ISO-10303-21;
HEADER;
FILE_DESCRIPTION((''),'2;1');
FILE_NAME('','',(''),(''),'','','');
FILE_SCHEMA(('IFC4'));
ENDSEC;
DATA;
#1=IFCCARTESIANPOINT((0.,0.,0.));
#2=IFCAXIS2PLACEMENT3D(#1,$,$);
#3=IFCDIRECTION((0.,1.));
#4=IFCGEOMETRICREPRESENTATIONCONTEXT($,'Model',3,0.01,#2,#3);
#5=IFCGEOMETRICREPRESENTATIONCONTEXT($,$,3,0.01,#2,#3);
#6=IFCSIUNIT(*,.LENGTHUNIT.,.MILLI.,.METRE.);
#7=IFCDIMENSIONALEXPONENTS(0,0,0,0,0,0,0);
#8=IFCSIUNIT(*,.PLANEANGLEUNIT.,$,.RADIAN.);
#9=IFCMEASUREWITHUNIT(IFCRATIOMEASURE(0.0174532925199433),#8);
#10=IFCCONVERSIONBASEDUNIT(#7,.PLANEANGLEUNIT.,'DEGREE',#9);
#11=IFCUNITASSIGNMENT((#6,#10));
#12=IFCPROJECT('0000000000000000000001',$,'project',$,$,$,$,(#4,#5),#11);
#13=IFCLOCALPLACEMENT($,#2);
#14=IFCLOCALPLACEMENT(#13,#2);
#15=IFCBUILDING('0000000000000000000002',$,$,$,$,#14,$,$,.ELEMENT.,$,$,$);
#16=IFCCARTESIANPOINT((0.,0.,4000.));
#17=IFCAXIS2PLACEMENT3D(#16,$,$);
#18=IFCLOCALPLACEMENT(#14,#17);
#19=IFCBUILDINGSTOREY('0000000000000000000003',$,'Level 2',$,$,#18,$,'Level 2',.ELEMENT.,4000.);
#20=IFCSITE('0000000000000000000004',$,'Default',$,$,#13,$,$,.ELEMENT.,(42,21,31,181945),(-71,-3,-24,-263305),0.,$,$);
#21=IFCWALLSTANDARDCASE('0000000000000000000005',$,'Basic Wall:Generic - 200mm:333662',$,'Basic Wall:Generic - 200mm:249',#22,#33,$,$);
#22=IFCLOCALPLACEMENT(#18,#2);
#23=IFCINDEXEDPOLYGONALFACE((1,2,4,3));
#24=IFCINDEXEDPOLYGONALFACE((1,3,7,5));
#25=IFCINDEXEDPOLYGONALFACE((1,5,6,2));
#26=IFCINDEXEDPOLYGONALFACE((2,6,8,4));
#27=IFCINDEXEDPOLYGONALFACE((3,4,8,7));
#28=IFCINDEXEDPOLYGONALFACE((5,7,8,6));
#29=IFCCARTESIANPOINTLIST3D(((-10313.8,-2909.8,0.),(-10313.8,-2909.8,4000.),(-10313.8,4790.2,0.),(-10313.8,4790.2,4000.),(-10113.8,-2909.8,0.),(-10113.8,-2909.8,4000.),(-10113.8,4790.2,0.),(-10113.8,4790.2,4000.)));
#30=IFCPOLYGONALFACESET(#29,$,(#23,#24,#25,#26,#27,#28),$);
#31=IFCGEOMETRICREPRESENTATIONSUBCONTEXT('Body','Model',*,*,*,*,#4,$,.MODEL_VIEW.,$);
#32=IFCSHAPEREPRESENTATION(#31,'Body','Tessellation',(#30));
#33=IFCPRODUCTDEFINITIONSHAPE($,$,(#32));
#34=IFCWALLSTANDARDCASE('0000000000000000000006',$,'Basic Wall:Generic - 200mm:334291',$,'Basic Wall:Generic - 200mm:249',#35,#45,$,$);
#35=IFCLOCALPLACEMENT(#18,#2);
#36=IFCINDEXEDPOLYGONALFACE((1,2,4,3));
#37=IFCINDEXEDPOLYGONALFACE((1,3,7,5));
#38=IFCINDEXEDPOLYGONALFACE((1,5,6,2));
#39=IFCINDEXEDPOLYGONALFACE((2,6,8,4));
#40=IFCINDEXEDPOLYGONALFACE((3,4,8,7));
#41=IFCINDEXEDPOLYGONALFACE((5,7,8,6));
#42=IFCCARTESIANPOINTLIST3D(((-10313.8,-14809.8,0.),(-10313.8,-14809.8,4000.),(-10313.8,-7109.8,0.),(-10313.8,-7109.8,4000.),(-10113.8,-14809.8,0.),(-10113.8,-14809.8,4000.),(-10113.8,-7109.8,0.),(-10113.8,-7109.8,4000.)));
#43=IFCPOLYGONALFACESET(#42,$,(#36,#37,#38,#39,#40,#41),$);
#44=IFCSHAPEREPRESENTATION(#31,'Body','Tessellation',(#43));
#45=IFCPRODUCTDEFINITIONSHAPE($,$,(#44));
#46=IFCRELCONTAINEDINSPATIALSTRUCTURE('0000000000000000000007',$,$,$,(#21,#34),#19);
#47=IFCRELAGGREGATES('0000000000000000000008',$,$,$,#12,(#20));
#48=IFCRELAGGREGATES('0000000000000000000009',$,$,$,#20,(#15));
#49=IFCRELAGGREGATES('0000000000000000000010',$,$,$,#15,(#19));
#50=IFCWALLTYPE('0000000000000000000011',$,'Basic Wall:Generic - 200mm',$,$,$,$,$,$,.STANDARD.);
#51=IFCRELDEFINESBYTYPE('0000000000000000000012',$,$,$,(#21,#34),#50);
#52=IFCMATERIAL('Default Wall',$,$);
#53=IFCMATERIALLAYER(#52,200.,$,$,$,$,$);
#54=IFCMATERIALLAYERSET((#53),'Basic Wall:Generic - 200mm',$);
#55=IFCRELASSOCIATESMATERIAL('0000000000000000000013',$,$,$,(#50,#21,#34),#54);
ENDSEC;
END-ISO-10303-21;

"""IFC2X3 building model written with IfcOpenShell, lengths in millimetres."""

from ifc_helpers import new_model, entity, si_unit, converted_unit, direction, frame, frame_2d, origin, place, context, subcontext, project, spatial, rectangle, extrude, clip, halfspace, material, layer, layer_set, layer_usage, type_object, element, save


model = new_model("IFC2X3")

# Units and contexts
model_context = context("Model", 3, precision=0.01, world=origin(), true_north=direction((0.0, 1.0)))
context_of_model = context(None, 3, precision=0.01, world=origin(), true_north=direction((0.0, 1.0)))
body_context = subcontext(model_context, "Body", "Model", "MODEL_VIEW")
ifc_project = project(units=[si_unit("LENGTHUNIT", "METRE", prefix="MILLI"), converted_unit("PLANEANGLEUNIT", "DEGREE", entity("IfcRatioMeasure", 0.0174532925199433), si_unit("PLANEANGLEUNIT", "RADIAN"), dimensions=[0, 0, 0, 0, 0, 0, 0])], contexts=[model_context, context_of_model])

# Site, building, storey
site_placement = place(None, origin())
site = spatial("IfcSite", under=ifc_project, at=site_placement, Name="Default", CompositionType="ELEMENT", RefLatitude=(42, 21, 31, 181945), RefLongitude=(-71, -3, -24, -263305), RefElevation=0.0)
building_placement = place(site_placement, origin())
building = spatial("IfcBuilding", under=site, at=building_placement, CompositionType="ELEMENT")
storey_placement = place(building_placement, frame((0.0, 0.0, 4000.0)))
storey = spatial("IfcBuildingStorey", under=building, at=storey_placement, Name="Level 2", LongName="Level 2", CompositionType="ELEMENT", Elevation=4000.0)

# Walls
ifc_material = material(Name="Default Wall")
ifc_layer = layer(ifc_material, 200.0)
ifc_layer_set = layer_set([ifc_layer], Name="Basic Wall:Generic - 200mm")
ifc_layer_usage_1 = layer_usage(ifc_layer_set, "AXIS2", "NEGATIVE", 100.0)
wall_type = type_object("IfcWallType", Name="Basic Wall:Generic - 200mm", PredefinedType="STANDARD", material=ifc_layer_set)
wall_1_placement = place(storey_placement, frame((-10213.8, 4790.2, 0.0), z_axis=(0.0, 0.0, 1.0), x_axis=(0.0, -1.0, 0.0)))
element("IfcWallStandardCase", 1, at=wall_1_placement, inside=storey, type_object=wall_type, material=ifc_layer_usage_1, Name="Basic Wall:Generic - 200mm:333662", ObjectType="Basic Wall:Generic - 200mm:249", context=body_context, shape_type="Clipping", body=[
    clip(extrude(rectangle(XDim=7700.0, YDim=200.0, at=frame_2d((3850.0, 0.0), x_axis=(-1.0, 0.0))), origin(), (0.0, 0.0, 1.0), 4000.0), halfspace(frame((0.0, 0.0, -4000.0)), True)),
])
ifc_layer_usage_2 = layer_usage(ifc_layer_set, "AXIS2", "NEGATIVE", 100.0)
wall_2_placement = place(storey_placement, frame((-10213.8, -7109.8, 0.0), z_axis=(0.0, 0.0, 1.0), x_axis=(0.0, -1.0, 0.0)))
element("IfcWallStandardCase", 2, at=wall_2_placement, inside=storey, type_object=wall_type, material=ifc_layer_usage_2, Name="Basic Wall:Generic - 200mm:334291", ObjectType="Basic Wall:Generic - 200mm:249", context=body_context, shape_type="Clipping", body=[
    clip(extrude(rectangle(XDim=7700.0, YDim=200.0, at=frame_2d((3850.0, 0.0), x_axis=(-1.0, 0.0))), origin(), (0.0, 0.0, 1.0), 4000.0), halfspace(frame((0.0, 0.0, -4000.0)), True)),
])

save(model, "model.ifc")
